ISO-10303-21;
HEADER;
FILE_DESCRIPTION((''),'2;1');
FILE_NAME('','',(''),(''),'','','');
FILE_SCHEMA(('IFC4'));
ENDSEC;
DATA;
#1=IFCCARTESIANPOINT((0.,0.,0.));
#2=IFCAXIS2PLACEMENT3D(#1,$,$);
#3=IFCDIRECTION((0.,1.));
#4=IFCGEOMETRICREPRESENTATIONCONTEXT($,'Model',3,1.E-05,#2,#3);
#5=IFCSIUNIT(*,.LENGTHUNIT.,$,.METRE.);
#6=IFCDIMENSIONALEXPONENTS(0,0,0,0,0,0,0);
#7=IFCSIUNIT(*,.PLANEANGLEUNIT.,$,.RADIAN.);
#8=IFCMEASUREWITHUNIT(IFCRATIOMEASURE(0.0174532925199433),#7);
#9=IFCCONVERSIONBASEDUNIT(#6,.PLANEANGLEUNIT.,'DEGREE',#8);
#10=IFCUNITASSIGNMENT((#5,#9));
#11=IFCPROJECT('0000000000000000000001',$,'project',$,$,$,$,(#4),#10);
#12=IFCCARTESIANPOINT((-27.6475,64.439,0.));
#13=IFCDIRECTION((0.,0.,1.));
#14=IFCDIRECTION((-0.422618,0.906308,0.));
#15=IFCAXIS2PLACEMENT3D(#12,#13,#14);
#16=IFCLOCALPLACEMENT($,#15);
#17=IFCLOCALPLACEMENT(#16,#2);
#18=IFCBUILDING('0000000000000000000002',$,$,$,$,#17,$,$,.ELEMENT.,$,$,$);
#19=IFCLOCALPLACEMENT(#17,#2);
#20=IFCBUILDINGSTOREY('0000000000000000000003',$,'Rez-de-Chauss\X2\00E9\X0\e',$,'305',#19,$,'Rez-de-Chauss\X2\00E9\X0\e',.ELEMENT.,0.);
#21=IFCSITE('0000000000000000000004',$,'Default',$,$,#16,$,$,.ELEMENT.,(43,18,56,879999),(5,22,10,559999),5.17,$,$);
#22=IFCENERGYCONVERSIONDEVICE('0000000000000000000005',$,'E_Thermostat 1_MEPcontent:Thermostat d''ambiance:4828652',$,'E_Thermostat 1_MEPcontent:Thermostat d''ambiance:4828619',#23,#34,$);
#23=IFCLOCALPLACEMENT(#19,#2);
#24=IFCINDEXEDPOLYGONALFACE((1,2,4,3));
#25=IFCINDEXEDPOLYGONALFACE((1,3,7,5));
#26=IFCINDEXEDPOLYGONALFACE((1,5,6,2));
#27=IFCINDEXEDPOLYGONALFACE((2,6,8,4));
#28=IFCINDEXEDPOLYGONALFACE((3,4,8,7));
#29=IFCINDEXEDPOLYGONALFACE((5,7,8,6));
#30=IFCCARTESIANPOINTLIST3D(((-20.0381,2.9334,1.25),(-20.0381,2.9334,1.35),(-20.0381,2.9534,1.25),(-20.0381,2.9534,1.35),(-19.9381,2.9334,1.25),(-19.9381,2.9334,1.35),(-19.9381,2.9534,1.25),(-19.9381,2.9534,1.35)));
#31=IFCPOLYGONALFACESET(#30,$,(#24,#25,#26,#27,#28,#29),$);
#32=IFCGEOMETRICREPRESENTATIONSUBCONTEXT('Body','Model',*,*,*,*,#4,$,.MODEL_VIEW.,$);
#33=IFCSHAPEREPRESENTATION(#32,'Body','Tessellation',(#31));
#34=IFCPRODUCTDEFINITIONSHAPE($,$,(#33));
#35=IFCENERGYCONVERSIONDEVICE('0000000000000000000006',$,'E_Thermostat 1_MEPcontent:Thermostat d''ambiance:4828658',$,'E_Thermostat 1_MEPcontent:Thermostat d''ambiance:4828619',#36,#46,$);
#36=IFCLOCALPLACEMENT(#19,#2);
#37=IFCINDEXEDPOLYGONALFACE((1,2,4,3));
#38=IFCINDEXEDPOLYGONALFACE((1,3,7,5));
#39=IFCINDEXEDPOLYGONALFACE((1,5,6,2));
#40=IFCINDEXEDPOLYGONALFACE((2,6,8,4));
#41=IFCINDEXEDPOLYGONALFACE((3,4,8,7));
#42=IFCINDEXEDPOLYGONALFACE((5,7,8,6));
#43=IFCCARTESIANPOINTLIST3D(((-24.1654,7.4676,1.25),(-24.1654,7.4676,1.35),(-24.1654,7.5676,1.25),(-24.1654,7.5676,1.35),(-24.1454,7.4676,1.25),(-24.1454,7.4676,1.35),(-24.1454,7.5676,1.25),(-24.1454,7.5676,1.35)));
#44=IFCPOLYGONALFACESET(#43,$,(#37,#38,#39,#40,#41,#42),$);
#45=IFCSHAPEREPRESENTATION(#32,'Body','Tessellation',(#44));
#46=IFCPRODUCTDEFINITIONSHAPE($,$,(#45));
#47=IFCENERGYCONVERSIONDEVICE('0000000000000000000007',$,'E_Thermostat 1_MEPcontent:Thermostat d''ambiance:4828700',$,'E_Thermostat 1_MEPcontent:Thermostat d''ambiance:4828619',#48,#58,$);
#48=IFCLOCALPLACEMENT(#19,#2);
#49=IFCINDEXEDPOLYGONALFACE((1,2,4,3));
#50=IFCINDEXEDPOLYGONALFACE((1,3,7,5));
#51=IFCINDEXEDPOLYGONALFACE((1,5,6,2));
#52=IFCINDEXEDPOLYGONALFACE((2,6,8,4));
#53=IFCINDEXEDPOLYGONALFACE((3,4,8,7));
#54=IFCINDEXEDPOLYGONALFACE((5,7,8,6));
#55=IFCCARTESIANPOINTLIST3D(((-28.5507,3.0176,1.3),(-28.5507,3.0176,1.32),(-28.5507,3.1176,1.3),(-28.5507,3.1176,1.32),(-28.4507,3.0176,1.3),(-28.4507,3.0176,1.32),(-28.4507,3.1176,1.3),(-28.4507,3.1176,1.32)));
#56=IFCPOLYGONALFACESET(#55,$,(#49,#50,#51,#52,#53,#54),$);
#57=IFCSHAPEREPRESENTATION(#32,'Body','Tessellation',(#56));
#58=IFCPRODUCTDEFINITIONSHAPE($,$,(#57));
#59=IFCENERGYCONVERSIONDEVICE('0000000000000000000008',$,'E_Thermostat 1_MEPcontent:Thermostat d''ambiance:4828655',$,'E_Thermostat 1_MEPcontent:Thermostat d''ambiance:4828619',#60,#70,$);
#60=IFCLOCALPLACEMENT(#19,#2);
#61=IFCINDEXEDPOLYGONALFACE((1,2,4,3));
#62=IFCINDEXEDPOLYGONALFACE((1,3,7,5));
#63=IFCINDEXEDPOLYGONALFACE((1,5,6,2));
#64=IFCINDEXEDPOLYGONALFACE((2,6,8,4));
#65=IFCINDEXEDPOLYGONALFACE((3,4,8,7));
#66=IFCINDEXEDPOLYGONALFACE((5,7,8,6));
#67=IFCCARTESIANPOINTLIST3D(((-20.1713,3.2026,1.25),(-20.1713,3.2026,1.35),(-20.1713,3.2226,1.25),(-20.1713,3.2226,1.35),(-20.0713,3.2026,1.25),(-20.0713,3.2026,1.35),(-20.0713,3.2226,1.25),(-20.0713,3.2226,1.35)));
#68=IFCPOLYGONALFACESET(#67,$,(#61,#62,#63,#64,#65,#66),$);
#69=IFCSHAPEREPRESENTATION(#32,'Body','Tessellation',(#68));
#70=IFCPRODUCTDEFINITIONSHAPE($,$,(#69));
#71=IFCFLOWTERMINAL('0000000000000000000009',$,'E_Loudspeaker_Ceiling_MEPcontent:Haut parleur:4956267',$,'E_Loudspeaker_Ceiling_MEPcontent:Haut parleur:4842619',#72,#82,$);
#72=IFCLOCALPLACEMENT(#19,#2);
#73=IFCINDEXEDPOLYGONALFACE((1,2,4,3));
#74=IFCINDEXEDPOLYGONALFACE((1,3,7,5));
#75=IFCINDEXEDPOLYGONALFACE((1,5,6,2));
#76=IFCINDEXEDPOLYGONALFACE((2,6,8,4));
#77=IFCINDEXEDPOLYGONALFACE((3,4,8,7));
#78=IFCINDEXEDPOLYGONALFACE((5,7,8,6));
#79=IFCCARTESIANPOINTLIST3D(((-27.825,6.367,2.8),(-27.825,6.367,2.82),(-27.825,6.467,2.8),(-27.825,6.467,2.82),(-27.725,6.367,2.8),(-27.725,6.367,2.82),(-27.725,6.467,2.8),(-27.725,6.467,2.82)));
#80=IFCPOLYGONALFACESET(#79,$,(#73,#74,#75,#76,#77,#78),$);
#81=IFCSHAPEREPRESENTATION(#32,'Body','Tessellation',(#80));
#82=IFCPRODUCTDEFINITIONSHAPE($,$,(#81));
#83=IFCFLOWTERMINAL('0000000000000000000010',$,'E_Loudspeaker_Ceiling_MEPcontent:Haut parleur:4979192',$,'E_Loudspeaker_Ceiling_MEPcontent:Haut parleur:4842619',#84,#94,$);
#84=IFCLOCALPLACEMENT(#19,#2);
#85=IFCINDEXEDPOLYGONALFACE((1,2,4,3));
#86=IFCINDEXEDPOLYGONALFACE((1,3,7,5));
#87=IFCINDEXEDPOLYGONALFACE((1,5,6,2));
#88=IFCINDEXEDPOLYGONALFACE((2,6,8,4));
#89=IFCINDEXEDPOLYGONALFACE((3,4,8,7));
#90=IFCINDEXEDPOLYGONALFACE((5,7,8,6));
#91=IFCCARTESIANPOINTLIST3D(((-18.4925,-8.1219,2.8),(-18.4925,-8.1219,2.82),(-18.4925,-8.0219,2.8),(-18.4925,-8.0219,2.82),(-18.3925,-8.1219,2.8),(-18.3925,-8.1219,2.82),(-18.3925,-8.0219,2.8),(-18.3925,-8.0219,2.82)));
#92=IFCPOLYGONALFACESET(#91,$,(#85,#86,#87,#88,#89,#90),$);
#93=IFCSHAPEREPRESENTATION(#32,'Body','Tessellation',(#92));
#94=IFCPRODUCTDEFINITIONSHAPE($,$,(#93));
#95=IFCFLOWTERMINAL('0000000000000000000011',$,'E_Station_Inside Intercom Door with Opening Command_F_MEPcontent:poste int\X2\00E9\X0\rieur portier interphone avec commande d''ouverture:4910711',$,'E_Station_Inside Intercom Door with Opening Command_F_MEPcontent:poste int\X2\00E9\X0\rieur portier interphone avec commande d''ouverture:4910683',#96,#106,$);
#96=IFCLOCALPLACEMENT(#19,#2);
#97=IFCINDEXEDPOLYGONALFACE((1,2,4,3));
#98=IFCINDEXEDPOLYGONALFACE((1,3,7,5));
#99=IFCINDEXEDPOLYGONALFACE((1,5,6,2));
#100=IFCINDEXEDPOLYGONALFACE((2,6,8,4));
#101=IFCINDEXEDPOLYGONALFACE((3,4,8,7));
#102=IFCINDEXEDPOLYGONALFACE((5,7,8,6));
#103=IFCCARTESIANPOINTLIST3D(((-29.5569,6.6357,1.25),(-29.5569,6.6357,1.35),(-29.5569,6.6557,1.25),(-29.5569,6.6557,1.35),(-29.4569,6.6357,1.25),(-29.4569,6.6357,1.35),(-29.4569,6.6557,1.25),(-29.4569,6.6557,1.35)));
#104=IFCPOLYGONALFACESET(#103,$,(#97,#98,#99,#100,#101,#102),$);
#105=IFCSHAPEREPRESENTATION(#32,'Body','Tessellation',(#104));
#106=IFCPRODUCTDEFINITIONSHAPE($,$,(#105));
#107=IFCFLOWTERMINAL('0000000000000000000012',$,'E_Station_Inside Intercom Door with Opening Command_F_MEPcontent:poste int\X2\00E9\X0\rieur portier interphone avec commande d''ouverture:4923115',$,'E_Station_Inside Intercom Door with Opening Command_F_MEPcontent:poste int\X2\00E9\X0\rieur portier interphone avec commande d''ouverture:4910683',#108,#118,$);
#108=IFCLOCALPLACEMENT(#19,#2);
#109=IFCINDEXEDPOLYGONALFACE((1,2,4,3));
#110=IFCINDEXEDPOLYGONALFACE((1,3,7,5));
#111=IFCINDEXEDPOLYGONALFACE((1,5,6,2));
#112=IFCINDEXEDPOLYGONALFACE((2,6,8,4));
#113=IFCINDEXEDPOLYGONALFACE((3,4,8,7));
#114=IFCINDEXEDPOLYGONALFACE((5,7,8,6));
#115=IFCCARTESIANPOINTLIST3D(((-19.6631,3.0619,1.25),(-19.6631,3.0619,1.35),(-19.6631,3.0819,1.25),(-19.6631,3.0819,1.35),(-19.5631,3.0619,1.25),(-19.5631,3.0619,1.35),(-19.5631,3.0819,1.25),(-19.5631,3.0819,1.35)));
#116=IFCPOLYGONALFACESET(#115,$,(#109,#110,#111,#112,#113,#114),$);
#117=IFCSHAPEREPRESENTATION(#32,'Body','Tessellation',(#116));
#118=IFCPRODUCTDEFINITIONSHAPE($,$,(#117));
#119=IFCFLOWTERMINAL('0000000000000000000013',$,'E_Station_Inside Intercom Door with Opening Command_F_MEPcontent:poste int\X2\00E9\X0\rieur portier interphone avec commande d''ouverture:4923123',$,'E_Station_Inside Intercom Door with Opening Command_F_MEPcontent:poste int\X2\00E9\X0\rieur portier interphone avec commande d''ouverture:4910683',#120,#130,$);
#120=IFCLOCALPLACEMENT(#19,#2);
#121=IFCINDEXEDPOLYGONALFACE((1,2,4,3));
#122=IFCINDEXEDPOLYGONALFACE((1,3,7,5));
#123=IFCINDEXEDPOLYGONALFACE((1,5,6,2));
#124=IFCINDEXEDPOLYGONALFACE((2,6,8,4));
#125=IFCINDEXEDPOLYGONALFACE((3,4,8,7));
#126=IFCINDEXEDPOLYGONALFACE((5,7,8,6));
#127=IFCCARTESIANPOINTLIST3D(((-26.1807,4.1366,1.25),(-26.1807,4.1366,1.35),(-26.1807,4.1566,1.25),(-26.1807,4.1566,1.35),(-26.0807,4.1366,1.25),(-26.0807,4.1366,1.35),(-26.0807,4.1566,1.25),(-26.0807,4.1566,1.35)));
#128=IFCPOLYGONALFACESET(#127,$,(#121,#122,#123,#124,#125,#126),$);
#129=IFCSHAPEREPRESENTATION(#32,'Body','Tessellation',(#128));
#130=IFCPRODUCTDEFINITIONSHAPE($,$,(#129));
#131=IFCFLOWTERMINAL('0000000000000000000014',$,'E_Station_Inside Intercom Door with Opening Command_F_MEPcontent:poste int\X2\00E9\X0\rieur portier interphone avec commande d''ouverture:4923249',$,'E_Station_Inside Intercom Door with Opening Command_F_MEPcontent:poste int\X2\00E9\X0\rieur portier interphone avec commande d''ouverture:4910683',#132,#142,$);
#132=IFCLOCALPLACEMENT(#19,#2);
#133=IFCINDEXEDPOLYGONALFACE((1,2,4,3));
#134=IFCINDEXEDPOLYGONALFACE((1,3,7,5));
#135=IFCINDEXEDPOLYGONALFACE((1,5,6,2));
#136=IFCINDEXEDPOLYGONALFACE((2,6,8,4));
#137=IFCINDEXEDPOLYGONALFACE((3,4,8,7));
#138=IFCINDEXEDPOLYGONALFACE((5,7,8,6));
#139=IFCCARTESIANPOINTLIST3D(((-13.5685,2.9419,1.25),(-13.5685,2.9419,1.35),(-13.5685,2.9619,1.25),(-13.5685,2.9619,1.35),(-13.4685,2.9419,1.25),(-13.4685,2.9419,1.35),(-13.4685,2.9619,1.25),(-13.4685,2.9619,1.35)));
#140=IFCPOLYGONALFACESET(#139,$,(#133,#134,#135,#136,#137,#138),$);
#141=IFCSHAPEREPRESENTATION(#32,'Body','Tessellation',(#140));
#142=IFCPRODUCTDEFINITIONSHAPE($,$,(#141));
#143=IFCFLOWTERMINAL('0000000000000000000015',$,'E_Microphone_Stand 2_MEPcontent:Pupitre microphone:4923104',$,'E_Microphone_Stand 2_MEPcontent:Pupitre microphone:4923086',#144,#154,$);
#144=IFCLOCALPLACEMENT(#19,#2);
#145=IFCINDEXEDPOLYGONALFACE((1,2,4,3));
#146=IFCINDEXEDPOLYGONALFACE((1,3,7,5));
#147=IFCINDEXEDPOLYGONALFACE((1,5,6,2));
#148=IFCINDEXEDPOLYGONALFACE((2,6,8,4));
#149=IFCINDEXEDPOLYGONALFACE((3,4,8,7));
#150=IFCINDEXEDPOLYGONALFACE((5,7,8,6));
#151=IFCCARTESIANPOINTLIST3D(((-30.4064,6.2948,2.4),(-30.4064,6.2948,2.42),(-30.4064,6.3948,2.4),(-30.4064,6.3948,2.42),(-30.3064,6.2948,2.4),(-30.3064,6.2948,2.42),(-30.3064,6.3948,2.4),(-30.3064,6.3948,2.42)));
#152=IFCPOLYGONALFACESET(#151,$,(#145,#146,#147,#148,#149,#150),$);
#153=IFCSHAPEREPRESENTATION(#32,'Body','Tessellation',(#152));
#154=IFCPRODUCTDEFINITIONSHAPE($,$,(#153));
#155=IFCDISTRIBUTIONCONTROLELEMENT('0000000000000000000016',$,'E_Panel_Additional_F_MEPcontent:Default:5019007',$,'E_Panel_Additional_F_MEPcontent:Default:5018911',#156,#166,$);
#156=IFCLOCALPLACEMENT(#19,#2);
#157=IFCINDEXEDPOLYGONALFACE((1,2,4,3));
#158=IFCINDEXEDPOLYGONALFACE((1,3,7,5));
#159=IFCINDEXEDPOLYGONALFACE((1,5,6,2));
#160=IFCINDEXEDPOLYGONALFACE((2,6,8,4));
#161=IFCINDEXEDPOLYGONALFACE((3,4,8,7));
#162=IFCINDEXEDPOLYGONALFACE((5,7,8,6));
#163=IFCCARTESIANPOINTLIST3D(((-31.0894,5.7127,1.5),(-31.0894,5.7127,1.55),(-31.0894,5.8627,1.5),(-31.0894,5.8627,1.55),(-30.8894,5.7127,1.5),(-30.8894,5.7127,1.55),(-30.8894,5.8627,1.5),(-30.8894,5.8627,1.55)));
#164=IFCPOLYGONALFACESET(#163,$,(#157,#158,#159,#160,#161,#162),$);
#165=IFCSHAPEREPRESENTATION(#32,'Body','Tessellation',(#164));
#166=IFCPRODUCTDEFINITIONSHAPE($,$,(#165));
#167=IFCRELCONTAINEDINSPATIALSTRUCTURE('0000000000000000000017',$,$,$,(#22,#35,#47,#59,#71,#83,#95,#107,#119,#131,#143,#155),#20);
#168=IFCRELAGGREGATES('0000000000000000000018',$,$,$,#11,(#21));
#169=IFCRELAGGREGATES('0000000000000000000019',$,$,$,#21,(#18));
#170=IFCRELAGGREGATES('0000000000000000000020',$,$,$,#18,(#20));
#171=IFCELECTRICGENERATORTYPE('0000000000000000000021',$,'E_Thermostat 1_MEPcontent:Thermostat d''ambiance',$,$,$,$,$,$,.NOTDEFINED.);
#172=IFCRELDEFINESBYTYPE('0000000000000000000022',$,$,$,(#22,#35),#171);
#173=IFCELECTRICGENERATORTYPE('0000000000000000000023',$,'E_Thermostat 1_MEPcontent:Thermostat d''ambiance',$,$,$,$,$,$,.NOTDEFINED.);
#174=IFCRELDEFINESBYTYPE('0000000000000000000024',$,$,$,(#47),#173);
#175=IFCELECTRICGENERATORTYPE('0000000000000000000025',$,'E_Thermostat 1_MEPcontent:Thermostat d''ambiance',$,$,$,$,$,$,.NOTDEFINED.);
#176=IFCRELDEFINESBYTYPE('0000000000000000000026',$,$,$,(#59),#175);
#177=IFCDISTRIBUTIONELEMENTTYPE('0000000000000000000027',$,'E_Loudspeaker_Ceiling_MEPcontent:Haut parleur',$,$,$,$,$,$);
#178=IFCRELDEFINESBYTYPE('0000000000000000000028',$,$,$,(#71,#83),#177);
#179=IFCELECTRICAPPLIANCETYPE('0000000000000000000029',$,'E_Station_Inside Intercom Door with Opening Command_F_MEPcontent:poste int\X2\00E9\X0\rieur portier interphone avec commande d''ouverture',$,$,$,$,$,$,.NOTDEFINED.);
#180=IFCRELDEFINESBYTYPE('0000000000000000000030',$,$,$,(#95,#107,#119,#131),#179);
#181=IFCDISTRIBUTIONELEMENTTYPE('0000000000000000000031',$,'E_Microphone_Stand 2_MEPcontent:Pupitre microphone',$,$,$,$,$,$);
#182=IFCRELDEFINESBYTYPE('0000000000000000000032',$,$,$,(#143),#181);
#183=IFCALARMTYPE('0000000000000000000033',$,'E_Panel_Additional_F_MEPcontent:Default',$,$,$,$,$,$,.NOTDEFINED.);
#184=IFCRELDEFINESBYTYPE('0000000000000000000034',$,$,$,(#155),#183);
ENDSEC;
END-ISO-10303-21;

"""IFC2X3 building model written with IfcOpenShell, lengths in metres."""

from ifc_helpers import new_model, entity, si_unit, converted_unit, direction, frame, frame_2d, origin, origin_2d_with_axis, place, context, subcontext, project, spatial, rectangle, extrude, source, transform, mapped, type_object, type_shapes, element, save


model = new_model("IFC2X3")

# Units and contexts
model_context = context("Model", 3, precision=1e-05, world=origin(), true_north=direction((0.0, 1.0)))
body_context = subcontext(model_context, "Body", "Model", "MODEL_VIEW")
ifc_project = project(units=[si_unit("LENGTHUNIT", "METRE"), converted_unit("PLANEANGLEUNIT", "DEGREE", entity("IfcRatioMeasure", 0.0174532925199433), si_unit("PLANEANGLEUNIT", "RADIAN"), dimensions=[0, 0, 0, 0, 0, 0, 0])], contexts=[model_context])

# Site, building, storey
site_placement = place(None, frame((-27.6475, 64.439, 0.0), z_axis=(0.0, 0.0, 1.0), x_axis=(-0.422618, 0.906308, 0.0)))
site = spatial("IfcSite", under=ifc_project, at=site_placement, Name="Default", CompositionType="ELEMENT", RefLatitude=(43, 18, 56, 879999), RefLongitude=(5, 22, 10, 559999), RefElevation=5.17)
building_placement = place(site_placement, origin())
building = spatial("IfcBuilding", under=site, at=building_placement, CompositionType="ELEMENT")
storey_placement = place(building_placement, origin())
storey = spatial("IfcBuildingStorey", under=building, at=storey_placement, Name="Rez-de-Chaussée", ObjectType="305", LongName="Rez-de-Chaussée", CompositionType="ELEMENT", Elevation=0.0)

# Energy conversion devices
electric_generator_type_1 = type_object("IfcElectricGeneratorType", Name="E_Thermostat 1_MEPcontent:Thermostat d'ambiance", PredefinedType="NOTDEFINED")
shared_shape_1 = source(origin(), body_context, "Body", "SweptSolid", [
    extrude(rectangle(XDim=0.02, YDim=0.1, at=frame_2d((0.0, 0.0), x_axis=(1.0, 0.0))), frame((0.0, 0.01, -0.05), z_axis=(0.0, 0.0, 1.0), x_axis=(0.0, -1.0, 0.0)), (0.0, 0.0, 1.0), 0.1),
])
type_shapes(electric_generator_type_1, [shared_shape_1])
for number, where, z_axis, x_axis, name in (
    (1, (-19.9881, 2.9534, 1.3), (0.0, 0.0, 1.0), (-1.0, 0.0, 0.0), "E_Thermostat 1_MEPcontent:Thermostat d'ambiance:4828652"),
    (2, (-24.1454, 7.5176, 1.3), (0.0, 0.0, 1.0), (0.0, 1.0, 0.0), "E_Thermostat 1_MEPcontent:Thermostat d'ambiance:4828658"),
):
    element("IfcEnergyConversionDevice", number, at=place(storey_placement, frame(where, z_axis=z_axis, x_axis=x_axis)), inside=storey, type_object=electric_generator_type_1, Name=name, ObjectType="E_Thermostat 1_MEPcontent:Thermostat d'ambiance:4828619", context=body_context, shape_type="MappedRepresentation", body=[
        mapped(shared_shape_1, transform((0.0, 0.0, 0.0), scale=1.0)),
    ])
electric_generator_type_2 = type_object("IfcElectricGeneratorType", Name="E_Thermostat 1_MEPcontent:Thermostat d'ambiance", PredefinedType="NOTDEFINED")
shared_shape_2 = source(origin(), body_context, "Body", "SweptSolid", [
    extrude(rectangle(XDim=0.1, YDim=0.1, at=origin_2d_with_axis()), frame((0.0, 0.0, 0.0), z_axis=(0.0, 0.0, 1.0), x_axis=(0.0, -1.0, 0.0)), (0.0, 0.0, 1.0), 0.02),
])
type_shapes(electric_generator_type_2, [shared_shape_2])
energy_conversion_device_1_placement = place(storey_placement, frame((-28.5007, 3.0676, 1.3)))
element("IfcEnergyConversionDevice", 3, at=energy_conversion_device_1_placement, inside=storey, type_object=electric_generator_type_2, Name="E_Thermostat 1_MEPcontent:Thermostat d'ambiance:4828700", ObjectType="E_Thermostat 1_MEPcontent:Thermostat d'ambiance:4828619", context=body_context, shape_type="MappedRepresentation", body=[
    mapped(shared_shape_2, transform((0.0, 0.0, 0.0), scale=1.0)),
])
electric_generator_type_3 = type_object("IfcElectricGeneratorType", Name="E_Thermostat 1_MEPcontent:Thermostat d'ambiance", PredefinedType="NOTDEFINED")
shared_shape_3 = source(origin(), body_context, "Body", "SweptSolid", [
    extrude(rectangle(XDim=0.02, YDim=0.1, at=frame_2d((0.0, 0.0), x_axis=(1.0, 0.0))), frame((-0.01, 0.0, -0.05)), (0.0, 0.0, 1.0), 0.1),
])
type_shapes(electric_generator_type_3, [shared_shape_3])
energy_conversion_device_2_placement = place(storey_placement, frame((-20.1213, 3.2026, 1.3), z_axis=(0.0, 0.0, 1.0), x_axis=(0.0, -1.0, 0.0)))
element("IfcEnergyConversionDevice", 4, at=energy_conversion_device_2_placement, inside=storey, type_object=electric_generator_type_3, Name="E_Thermostat 1_MEPcontent:Thermostat d'ambiance:4828655", ObjectType="E_Thermostat 1_MEPcontent:Thermostat d'ambiance:4828619", context=body_context, shape_type="MappedRepresentation", body=[
    mapped(shared_shape_3, transform((0.0, 0.0, 0.0), scale=1.0)),
])

# Flow terminals
distribution_element_type_1 = type_object("IfcDistributionElementType", Name="E_Loudspeaker_Ceiling_MEPcontent:Haut parleur")
shared_shape_4 = source(origin(), body_context, "Body", "SweptSolid", [
    extrude(rectangle(XDim=0.1, YDim=0.1, at=origin_2d_with_axis()), frame((0.0, 0.0, 0.0), z_axis=(0.0, 0.0, 1.0), x_axis=(0.0, -1.0, 0.0)), (0.0, 0.0, 1.0), 0.02),
])
type_shapes(distribution_element_type_1, [shared_shape_4])
for number, where, z_axis, x_axis, name in (
    (5, (-27.775, 6.417, 2.8), (0.0, 0.0, 1.0), (-1.0, 0.0, 0.0), "E_Loudspeaker_Ceiling_MEPcontent:Haut parleur:4956267"),
    (6, (-18.4425, -8.0719, 2.8), (0.0, 0.0, 1.0), (-1.0, 0.0, 0.0), "E_Loudspeaker_Ceiling_MEPcontent:Haut parleur:4979192"),
):
    element("IfcFlowTerminal", number, at=place(storey_placement, frame(where, z_axis=z_axis, x_axis=x_axis)), inside=storey, type_object=distribution_element_type_1, Name=name, ObjectType="E_Loudspeaker_Ceiling_MEPcontent:Haut parleur:4842619", context=body_context, shape_type="MappedRepresentation", body=[
        mapped(shared_shape_4, transform((0.0, 0.0, 0.0), scale=1.0)),
    ])
electric_appliance_type = type_object("IfcElectricApplianceType", Name="E_Station_Inside Intercom Door with Opening Command_F_MEPcontent:poste intérieur portier interphone avec commande d'ouverture", PredefinedType="NOTDEFINED")
shared_shape_5 = source(origin(), body_context, "Body", "SweptSolid", [
    extrude(rectangle(XDim=0.1, YDim=0.1, at=origin_2d_with_axis()), frame((0.0, 0.0, 0.0), z_axis=(0.0, 0.0, 1.0), x_axis=(0.0, 1.0, 0.0)), (0.0, 0.0, 1.0), 0.02),
])
type_shapes(electric_appliance_type, [shared_shape_5])
for number, where, z_axis, x_axis, name in (
    (7, (-29.5069, 6.6557, 1.3), (0.0, -1.0, 0.0), (1.0, 0.0, 0.0), "E_Station_Inside Intercom Door with Opening Command_F_MEPcontent:poste intérieur portier interphone avec commande d'ouverture:4910711"),
    (8, (-19.6131, 3.0619, 1.3), (0.0, 1.0, 0.0), (-1.0, 0.0, 0.0), "E_Station_Inside Intercom Door with Opening Command_F_MEPcontent:poste intérieur portier interphone avec commande d'ouverture:4923115"),
    (9, (-26.1307, 4.1566, 1.3), (0.0, -1.0, 0.0), (1.0, 0.0, 0.0), "E_Station_Inside Intercom Door with Opening Command_F_MEPcontent:poste intérieur portier interphone avec commande d'ouverture:4923123"),
    (10, (-13.5185, 2.9619, 1.3), (0.0, -1.0, 0.0), (1.0, 0.0, 0.0), "E_Station_Inside Intercom Door with Opening Command_F_MEPcontent:poste intérieur portier interphone avec commande d'ouverture:4923249"),
):
    element("IfcFlowTerminal", number, at=place(storey_placement, frame(where, z_axis=z_axis, x_axis=x_axis)), inside=storey, type_object=electric_appliance_type, Name=name, ObjectType="E_Station_Inside Intercom Door with Opening Command_F_MEPcontent:poste intérieur portier interphone avec commande d'ouverture:4910683", context=body_context, shape_type="MappedRepresentation", body=[
        mapped(shared_shape_5, transform((0.0, 0.0, 0.0), scale=1.0)),
    ])
distribution_element_type_2 = type_object("IfcDistributionElementType", Name="E_Microphone_Stand 2_MEPcontent:Pupitre microphone")
shared_shape_6 = source(origin(), body_context, "Body", "SweptSolid", [
    extrude(rectangle(XDim=0.1, YDim=0.1, at=origin_2d_with_axis()), frame((0.0, 0.0, 0.0), z_axis=(0.0, 0.0, 1.0), x_axis=(0.0, -1.0, 0.0)), (0.0, 0.0, 1.0), 0.02),
])
type_shapes(distribution_element_type_2, [shared_shape_6])
flow_terminal_1_placement = place(storey_placement, frame((-30.3564, 6.3448, 2.4), z_axis=(0.0, 0.0, 1.0), x_axis=(0.0, -1.0, 0.0)))
element("IfcFlowTerminal", 11, at=flow_terminal_1_placement, inside=storey, type_object=distribution_element_type_2, Name="E_Microphone_Stand 2_MEPcontent:Pupitre microphone:4923104", ObjectType="E_Microphone_Stand 2_MEPcontent:Pupitre microphone:4923086", context=body_context, shape_type="MappedRepresentation", body=[
    mapped(shared_shape_6, transform((0.0, 0.0, 0.0), scale=1.0)),
])

# Distribution control element
alarm_type_1 = type_object("IfcAlarmType", Name="E_Panel_Additional_F_MEPcontent:Default", PredefinedType="NOTDEFINED")
shared_shape_7 = source(origin(), body_context, "Body", "SweptSolid", [
    extrude(rectangle(XDim=0.15, YDim=0.05, at=frame_2d((0.0, 0.0), x_axis=(1.0, 0.0))), frame((0.0, 0.025, 0.0)), (0.0, 0.0, 1.0), 0.2),
])
type_shapes(alarm_type_1, [shared_shape_7])
distribution_control_element_1_placement = place(storey_placement, frame((-31.0894, 5.7877, 1.5), z_axis=(1.0, 0.0, 0.0), x_axis=(0.0, 1.0, 0.0)))
element("IfcDistributionControlElement", 12, at=distribution_control_element_1_placement, inside=storey, type_object=alarm_type_1, Name="E_Panel_Additional_F_MEPcontent:Default:5019007", ObjectType="E_Panel_Additional_F_MEPcontent:Default:5018911", context=body_context, shape_type="MappedRepresentation", body=[
    mapped(shared_shape_7, transform((0.0, 0.0, 0.0), scale=1.0)),
])

save(model, "model.ifc")
